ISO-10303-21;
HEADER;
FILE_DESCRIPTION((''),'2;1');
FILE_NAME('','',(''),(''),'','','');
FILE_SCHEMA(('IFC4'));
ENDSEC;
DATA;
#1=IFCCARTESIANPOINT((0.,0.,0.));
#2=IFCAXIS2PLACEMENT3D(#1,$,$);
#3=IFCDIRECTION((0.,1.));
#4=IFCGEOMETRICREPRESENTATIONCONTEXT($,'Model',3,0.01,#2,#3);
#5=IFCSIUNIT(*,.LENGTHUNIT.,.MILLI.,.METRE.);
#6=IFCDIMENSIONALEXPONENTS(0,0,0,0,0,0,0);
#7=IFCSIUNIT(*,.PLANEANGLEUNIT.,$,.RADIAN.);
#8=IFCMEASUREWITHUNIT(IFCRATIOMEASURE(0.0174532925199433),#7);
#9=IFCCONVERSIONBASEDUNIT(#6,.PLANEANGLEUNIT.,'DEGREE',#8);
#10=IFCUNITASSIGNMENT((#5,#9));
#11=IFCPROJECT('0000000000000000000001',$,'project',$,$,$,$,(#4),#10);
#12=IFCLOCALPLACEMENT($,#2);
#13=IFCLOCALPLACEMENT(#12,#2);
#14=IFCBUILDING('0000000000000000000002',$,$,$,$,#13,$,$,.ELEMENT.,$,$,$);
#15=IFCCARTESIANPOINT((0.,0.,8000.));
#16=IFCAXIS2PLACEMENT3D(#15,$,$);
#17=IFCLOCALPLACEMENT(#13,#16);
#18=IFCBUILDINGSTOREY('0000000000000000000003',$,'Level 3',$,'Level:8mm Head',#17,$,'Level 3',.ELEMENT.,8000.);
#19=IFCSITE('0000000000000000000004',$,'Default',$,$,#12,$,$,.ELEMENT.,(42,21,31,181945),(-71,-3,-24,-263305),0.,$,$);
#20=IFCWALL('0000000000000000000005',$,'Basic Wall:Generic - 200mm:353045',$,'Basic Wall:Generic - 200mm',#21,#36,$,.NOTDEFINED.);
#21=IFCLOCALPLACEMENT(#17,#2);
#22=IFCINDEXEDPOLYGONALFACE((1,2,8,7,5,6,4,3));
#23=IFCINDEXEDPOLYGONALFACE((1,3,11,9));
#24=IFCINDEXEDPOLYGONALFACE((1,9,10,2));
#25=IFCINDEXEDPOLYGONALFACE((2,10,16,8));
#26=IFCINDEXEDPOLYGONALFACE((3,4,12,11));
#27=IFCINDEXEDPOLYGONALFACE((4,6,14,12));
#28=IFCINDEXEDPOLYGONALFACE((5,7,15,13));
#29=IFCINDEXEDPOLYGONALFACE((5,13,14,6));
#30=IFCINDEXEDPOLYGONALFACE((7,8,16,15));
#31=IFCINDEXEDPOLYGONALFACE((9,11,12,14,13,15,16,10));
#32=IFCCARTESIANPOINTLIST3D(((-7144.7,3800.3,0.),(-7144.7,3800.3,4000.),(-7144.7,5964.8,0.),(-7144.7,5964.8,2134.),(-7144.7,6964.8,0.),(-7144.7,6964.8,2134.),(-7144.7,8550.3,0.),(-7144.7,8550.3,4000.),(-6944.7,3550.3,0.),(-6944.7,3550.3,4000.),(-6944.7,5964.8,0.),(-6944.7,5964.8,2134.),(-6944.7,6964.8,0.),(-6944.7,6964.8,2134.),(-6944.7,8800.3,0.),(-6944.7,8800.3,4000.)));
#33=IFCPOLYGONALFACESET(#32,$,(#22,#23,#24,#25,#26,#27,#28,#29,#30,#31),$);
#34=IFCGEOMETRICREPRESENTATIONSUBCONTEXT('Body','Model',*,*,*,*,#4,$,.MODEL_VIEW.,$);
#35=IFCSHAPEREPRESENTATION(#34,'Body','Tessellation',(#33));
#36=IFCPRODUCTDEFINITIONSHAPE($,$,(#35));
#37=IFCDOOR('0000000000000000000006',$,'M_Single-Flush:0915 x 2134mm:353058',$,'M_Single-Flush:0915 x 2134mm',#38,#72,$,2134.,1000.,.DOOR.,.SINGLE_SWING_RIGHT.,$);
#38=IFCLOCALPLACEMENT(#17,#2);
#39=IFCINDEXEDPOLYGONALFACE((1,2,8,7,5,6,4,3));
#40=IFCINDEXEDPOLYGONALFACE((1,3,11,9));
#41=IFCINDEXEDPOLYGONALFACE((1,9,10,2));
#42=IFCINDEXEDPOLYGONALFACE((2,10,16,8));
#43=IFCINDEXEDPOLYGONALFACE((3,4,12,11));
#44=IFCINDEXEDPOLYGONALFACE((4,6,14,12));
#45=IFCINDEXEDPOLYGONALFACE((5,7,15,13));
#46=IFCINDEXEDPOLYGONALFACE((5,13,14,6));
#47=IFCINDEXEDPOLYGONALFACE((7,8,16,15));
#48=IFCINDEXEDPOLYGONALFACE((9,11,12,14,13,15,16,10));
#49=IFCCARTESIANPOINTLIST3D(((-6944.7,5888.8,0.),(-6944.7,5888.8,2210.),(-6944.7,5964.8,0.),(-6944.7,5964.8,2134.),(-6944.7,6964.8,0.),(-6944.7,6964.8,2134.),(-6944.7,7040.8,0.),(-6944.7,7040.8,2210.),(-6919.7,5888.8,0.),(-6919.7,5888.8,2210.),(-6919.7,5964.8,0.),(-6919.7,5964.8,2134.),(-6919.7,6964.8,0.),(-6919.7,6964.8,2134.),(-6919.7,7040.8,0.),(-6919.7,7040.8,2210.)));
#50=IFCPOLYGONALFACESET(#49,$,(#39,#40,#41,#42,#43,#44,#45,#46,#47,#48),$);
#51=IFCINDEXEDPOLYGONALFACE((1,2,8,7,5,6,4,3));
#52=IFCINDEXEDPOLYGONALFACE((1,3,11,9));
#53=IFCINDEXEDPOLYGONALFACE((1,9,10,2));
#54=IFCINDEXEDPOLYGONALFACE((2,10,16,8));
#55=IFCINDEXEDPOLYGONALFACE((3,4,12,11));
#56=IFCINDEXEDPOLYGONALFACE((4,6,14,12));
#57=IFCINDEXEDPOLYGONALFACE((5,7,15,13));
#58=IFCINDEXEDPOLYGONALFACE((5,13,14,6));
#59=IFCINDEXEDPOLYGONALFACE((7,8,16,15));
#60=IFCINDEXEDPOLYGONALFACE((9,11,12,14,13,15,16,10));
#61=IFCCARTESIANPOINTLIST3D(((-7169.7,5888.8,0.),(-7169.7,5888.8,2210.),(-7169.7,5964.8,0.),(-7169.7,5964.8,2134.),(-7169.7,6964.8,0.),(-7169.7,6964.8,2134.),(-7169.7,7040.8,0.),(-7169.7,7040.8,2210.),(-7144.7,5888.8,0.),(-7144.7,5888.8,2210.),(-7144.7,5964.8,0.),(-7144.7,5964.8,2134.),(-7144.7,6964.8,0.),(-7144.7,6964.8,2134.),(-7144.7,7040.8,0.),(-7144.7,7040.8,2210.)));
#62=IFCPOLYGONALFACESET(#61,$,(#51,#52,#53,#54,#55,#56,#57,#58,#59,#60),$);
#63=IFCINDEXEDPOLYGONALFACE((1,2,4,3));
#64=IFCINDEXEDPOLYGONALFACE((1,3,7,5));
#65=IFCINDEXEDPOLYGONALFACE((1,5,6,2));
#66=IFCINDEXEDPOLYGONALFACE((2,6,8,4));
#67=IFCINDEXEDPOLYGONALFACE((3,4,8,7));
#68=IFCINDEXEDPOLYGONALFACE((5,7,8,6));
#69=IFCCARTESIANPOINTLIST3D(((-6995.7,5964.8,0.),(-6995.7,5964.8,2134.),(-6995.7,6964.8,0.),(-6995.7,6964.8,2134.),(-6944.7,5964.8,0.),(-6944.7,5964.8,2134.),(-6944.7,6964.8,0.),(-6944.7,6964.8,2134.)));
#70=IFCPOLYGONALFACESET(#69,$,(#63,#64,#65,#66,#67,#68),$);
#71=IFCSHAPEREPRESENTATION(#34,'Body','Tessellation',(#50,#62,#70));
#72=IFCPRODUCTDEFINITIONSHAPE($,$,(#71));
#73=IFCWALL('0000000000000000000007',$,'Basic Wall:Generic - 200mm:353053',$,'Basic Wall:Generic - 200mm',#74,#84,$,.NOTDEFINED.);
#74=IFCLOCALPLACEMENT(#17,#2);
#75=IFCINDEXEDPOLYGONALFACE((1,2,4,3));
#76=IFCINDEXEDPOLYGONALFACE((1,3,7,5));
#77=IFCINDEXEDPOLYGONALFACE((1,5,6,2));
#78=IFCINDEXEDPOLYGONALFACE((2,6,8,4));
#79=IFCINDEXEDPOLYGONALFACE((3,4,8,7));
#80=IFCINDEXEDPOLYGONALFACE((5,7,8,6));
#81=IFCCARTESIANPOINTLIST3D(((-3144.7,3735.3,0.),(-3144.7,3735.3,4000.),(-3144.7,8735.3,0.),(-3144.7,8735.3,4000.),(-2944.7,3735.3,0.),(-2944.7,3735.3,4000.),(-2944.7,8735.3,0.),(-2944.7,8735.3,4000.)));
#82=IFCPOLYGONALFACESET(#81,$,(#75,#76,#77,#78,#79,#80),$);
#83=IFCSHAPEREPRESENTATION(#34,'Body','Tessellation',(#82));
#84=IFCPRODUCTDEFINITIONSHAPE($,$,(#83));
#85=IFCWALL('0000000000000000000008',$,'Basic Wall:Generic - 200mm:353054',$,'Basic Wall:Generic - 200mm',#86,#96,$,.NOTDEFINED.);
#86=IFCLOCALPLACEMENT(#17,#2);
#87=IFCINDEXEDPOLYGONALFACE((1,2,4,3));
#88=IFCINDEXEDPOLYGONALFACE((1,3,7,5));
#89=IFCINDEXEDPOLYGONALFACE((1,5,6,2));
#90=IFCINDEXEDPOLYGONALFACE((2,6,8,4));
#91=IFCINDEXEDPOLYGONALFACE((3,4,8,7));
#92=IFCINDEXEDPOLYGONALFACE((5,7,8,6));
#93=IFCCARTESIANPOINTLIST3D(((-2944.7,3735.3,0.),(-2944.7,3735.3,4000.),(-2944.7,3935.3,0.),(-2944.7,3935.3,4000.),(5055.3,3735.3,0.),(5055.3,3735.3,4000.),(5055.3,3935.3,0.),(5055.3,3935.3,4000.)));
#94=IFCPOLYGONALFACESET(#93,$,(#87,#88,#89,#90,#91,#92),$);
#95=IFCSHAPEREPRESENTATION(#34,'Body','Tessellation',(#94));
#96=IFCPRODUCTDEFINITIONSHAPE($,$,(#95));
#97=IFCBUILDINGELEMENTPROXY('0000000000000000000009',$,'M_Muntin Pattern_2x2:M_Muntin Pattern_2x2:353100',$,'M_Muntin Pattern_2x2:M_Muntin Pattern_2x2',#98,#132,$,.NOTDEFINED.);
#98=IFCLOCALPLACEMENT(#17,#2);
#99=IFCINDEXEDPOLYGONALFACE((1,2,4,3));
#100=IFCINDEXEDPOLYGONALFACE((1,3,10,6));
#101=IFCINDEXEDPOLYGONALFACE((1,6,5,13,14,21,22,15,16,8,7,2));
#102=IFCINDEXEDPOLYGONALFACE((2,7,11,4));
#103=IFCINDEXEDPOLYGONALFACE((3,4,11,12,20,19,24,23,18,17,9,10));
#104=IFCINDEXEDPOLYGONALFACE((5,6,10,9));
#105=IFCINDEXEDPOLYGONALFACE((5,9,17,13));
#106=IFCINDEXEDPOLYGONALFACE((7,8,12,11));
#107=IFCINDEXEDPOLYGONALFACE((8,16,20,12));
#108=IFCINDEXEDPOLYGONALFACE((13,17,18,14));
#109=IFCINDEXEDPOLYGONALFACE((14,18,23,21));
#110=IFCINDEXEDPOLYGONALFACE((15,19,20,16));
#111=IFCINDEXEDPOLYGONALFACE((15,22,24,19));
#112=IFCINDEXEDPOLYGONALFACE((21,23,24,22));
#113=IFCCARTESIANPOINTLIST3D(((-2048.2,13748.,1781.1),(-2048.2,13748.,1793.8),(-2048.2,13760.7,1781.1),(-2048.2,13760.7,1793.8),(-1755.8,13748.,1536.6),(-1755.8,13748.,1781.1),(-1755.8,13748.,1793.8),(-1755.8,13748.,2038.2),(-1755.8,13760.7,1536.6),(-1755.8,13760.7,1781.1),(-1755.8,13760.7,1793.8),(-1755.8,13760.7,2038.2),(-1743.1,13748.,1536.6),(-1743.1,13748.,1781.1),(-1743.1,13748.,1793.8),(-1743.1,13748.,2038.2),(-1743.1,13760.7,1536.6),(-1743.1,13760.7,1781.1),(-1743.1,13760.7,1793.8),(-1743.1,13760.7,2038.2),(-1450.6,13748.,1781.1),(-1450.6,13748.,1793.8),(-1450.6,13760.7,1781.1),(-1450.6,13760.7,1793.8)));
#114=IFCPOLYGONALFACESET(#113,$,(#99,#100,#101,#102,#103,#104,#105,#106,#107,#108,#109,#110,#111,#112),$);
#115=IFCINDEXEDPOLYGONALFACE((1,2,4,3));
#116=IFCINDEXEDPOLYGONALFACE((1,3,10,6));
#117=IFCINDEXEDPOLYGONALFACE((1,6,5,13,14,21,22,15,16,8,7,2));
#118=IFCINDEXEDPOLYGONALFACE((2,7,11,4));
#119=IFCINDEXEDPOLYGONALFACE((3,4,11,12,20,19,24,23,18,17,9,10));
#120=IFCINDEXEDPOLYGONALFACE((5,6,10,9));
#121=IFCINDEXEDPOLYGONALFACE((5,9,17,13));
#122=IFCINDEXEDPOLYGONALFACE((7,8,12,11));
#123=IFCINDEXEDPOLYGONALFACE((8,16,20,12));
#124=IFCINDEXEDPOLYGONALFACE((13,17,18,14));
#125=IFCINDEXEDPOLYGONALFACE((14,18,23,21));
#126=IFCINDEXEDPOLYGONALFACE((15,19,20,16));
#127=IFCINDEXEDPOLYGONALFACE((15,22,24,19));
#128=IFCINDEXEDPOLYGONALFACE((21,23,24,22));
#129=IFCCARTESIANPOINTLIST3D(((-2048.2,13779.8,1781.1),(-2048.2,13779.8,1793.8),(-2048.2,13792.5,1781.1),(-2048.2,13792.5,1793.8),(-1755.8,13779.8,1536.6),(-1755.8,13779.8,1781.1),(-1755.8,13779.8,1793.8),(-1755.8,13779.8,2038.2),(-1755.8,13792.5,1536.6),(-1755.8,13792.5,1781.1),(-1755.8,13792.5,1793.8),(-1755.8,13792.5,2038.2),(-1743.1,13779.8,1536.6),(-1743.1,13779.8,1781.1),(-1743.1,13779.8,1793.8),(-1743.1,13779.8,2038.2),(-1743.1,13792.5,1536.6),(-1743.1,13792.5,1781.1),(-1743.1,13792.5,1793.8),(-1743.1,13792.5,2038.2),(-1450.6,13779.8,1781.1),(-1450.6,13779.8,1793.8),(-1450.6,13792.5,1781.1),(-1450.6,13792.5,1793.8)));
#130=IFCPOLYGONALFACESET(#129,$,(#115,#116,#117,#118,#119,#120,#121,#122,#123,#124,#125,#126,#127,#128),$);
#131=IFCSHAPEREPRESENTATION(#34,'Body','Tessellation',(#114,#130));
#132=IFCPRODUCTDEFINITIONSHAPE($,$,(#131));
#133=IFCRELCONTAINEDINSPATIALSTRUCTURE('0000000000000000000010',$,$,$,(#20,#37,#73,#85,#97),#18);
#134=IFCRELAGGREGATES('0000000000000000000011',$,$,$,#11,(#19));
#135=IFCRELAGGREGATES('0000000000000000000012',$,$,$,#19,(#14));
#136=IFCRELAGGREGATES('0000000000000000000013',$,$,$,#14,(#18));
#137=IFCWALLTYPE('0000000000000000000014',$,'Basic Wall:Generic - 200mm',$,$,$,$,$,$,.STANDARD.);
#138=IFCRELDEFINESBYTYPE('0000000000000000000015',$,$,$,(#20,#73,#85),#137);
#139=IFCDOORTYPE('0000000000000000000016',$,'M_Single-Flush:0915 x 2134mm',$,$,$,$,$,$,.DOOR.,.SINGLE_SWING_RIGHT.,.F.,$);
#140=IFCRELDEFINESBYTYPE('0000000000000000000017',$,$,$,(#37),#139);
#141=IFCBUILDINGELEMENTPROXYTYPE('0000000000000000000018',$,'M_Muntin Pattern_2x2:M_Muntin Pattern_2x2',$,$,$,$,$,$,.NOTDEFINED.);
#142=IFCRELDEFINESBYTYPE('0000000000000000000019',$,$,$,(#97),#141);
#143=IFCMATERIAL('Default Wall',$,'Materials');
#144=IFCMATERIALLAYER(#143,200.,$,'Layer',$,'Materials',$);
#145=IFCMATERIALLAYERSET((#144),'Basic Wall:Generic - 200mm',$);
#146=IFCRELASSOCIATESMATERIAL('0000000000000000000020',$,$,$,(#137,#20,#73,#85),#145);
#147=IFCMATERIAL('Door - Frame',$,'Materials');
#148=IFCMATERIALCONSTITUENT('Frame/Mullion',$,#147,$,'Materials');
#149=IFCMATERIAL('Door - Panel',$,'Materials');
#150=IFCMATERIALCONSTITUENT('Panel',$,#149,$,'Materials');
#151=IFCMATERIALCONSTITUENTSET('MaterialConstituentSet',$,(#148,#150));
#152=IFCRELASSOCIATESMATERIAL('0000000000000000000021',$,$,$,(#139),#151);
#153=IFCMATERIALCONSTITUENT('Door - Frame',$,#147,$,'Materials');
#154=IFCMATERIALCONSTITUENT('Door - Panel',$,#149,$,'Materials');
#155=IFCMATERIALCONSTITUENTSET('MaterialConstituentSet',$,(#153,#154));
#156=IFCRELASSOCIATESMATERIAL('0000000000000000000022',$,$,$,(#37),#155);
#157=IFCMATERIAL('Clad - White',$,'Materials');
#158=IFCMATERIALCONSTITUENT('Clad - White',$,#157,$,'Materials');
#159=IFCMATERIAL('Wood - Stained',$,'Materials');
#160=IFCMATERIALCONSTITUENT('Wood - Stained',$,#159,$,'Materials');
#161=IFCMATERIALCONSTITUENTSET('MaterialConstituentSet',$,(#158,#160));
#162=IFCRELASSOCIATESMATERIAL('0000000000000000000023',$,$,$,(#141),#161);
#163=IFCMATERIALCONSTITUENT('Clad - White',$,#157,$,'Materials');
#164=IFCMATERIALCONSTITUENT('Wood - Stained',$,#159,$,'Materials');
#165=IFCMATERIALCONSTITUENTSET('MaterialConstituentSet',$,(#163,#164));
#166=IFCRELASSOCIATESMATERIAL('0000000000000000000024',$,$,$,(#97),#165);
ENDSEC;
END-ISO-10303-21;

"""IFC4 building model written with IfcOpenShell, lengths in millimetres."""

from ifc_helpers import new_model, entity, si_unit, converted_unit, direction, frame, frame_2d, origin, place, context, subcontext, project, spatial, polyline, rectangle, outline, extrude, source, transform, mapped, material, layer, layer_set, layer_usage, constituent, constituent_set, type_object, type_shapes, element, fill, save


model = new_model("IFC4")

# Units and contexts
model_context = context("Model", 3, precision=0.01, world=origin(), true_north=direction((0.0, 1.0)))
body_context = subcontext(model_context, "Body", "Model", "MODEL_VIEW")
ifc_project = project(units=[si_unit("LENGTHUNIT", "METRE", prefix="MILLI"), converted_unit("PLANEANGLEUNIT", "DEGREE", entity("IfcRatioMeasure", 0.0174532925199433), si_unit("PLANEANGLEUNIT", "RADIAN"), dimensions=[0, 0, 0, 0, 0, 0, 0])], contexts=[model_context])

# Site, building, storey
site_placement = place(None, origin())
site = spatial("IfcSite", under=ifc_project, at=site_placement, Name="Default", CompositionType="ELEMENT", RefLatitude=(42, 21, 31, 181945), RefLongitude=(-71, -3, -24, -263305), RefElevation=0.0)
building_placement = place(site_placement, origin())
building = spatial("IfcBuilding", under=site, at=building_placement, CompositionType="ELEMENT")
storey_placement = place(building_placement, frame((0.0, 0.0, 8000.0)))
storey = spatial("IfcBuildingStorey", under=building, at=storey_placement, Name="Level 3", ObjectType="Level:8mm Head", LongName="Level 3", CompositionType="ELEMENT", Elevation=8000.0)

# Shared definitions
ifc_material_1 = material(Name="Default Wall", Category="Materials")
ifc_layer = layer(ifc_material_1, 200.0, Name="Layer", Category="Materials")
ifc_layer_set = layer_set([ifc_layer], Name="Basic Wall:Generic - 200mm")
wall_type = type_object("IfcWallType", Name="Basic Wall:Generic - 200mm", PredefinedType="STANDARD", material=ifc_layer_set)
ifc_material_2 = material(Name="Door - Frame", Category="Materials")
ifc_material_3 = material(Name="Door - Panel", Category="Materials")
ifc_constituent_1 = constituent(ifc_material_2, Name="Frame/Mullion", Category="Materials")
ifc_constituent_2 = constituent(ifc_material_3, Name="Panel", Category="Materials")
ifc_constituent_set_1 = constituent_set(constituents=[ifc_constituent_1, ifc_constituent_2], Name="MaterialConstituentSet")
door_type = type_object("IfcDoorType", Name="M_Single-Flush:0915 x 2134mm", OperationType="SINGLE_SWING_RIGHT", ParameterTakesPrecedence=False, PredefinedType="DOOR", material=ifc_constituent_set_1)
shared_shape_1 = source(origin(), body_context, "Body", "SweptSolid", [
    extrude(outline(polyline([(-576.0, -1124.0), (576.0, -1124.0), (576.0, 1086.0), (500.0, 1086.0), (500.0, -1048.0), (-500.0, -1048.0), (-500.0, 1086.0), (-576.0, 1086.0), (-576.0, -1124.0)])), frame((500.0, 200.0, 1086.0), z_axis=(0.0, 1.0, 0.0), x_axis=(1.0, 0.0, 0.0)), (0.0, 0.0, 1.0), 25.0),
    extrude(outline(polyline([(-1124.0, -576.0), (1086.0, -576.0), (1086.0, -500.0), (-1048.0, -500.0), (-1048.0, 500.0), (1086.0, 500.0), (1086.0, 576.0), (-1124.0, 576.0), (-1124.0, -576.0)])), frame((500.0, -25.0, 1086.0), z_axis=(0.0, 1.0, 0.0), x_axis=(0.0, 0.0, -1.0)), (0.0, 0.0, 1.0), 25.0),
    extrude(rectangle(XDim=51.0, YDim=1000.0, at=frame_2d((0.0, 0.0), x_axis=(1.0, 0.0))), frame((500.0, 174.5, 0.0), z_axis=(0.0, 0.0, 1.0), x_axis=(0.0, 1.0, 0.0)), (0.0, 0.0, 1.0), 2134.0),
])
type_shapes(door_type, [shared_shape_1])
ifc_material_4 = material(Name="Wood - Stained", Category="Materials")

# Wall, opening, door
ifc_layer_usage_1 = layer_usage(ifc_layer_set, "AXIS2", "NEGATIVE", 100.0)
wall_1_placement = place(storey_placement, frame((-7044.7, 8800.3, 0.0), z_axis=(0.0, 0.0, 1.0), x_axis=(0.0, -1.0, 0.0)))
wall_1 = element("IfcWall", 1, at=wall_1_placement, inside=storey, type_object=wall_type, material=ifc_layer_usage_1, Name="Basic Wall:Generic - 200mm:353045", ObjectType="Basic Wall:Generic - 200mm", PredefinedType="NOTDEFINED", context=body_context, shape_type="SweptSolid", body=[
    extrude(outline(polyline([(250.0, -100.0), (5000.0, -100.0), (5250.0, 100.0), (4929.8, 100.0), (0.0, 100.0), (250.0, -100.0)])), origin(), (0.0, 0.0, 1.0), 4000.0),
])
opening_1_placement = place(wall_1_placement, frame((1835.4, -100.0, 0.0)))
opening_1 = element("IfcOpeningElement", 2, at=opening_1_placement, cuts=wall_1, PredefinedType="OPENING", context=body_context, shape_type="SweptSolid", body=[
    extrude(rectangle(XDim=1000.0, YDim=2134.0, at=frame_2d((1067.0, 500.0), x_axis=(0.0, 1.0))), frame((0.0, 0.0, 0.0), z_axis=(0.0, 1.0, 0.0), x_axis=(0.0, 0.0, 1.0)), (0.0, 0.0, 1.0), 200.0),
])
ifc_constituent_3 = constituent(ifc_material_2, Name="Door - Frame", Category="Materials")
ifc_constituent_4 = constituent(ifc_material_3, Name="Door - Panel", Category="Materials")
ifc_constituent_set_2 = constituent_set(constituents=[ifc_constituent_3, ifc_constituent_4], Name="MaterialConstituentSet")
door_1_placement = place(opening_1_placement, origin())
door_1 = element("IfcDoor", 3, at=door_1_placement, inside=storey, type_object=door_type, material=ifc_constituent_set_2, Name="M_Single-Flush:0915 x 2134mm:353058", ObjectType="M_Single-Flush:0915 x 2134mm", OperationType="SINGLE_SWING_RIGHT", OverallHeight=2134.0, OverallWidth=1000.0, PredefinedType="DOOR", context=body_context, shape_type="MappedRepresentation", body=[
    mapped(shared_shape_1, transform((0.0, 0.0, 0.0), scale=1.0)),
])
fill(opening_1, door_1)

# Walls
ifc_layer_usage_2 = layer_usage(ifc_layer_set, "AXIS2", "NEGATIVE", 100.0)
wall_2_placement = place(storey_placement, frame((-3044.7, 8735.3, 0.0), z_axis=(0.0, 0.0, 1.0), x_axis=(0.0, -1.0, 0.0)))
element("IfcWall", 4, at=wall_2_placement, inside=storey, type_object=wall_type, material=ifc_layer_usage_2, Name="Basic Wall:Generic - 200mm:353053", ObjectType="Basic Wall:Generic - 200mm", PredefinedType="NOTDEFINED", context=body_context, shape_type="SweptSolid", body=[
    extrude(rectangle(XDim=5000.0, YDim=200.0, at=frame_2d((2500.0, 0.0), x_axis=(-1.0, 0.0))), origin(), (0.0, 0.0, 1.0), 4000.0),
])
ifc_layer_usage_3 = layer_usage(ifc_layer_set, "AXIS2", "NEGATIVE", 100.0)
wall_3_placement = place(storey_placement, frame((-2944.7, 3835.3, 0.0)))
element("IfcWall", 5, at=wall_3_placement, inside=storey, type_object=wall_type, material=ifc_layer_usage_3, Name="Basic Wall:Generic - 200mm:353054", ObjectType="Basic Wall:Generic - 200mm", PredefinedType="NOTDEFINED", context=body_context, shape_type="SweptSolid", body=[
    extrude(rectangle(XDim=8000.0, YDim=200.0, at=frame_2d((4000.0, 0.0), x_axis=(-1.0, 0.0))), origin(), (0.0, 0.0, 1.0), 4000.0),
])

# Building element proxy
ifc_material_5 = material(Name="Clad - White", Category="Materials")
ifc_constituent_5 = constituent(ifc_material_5, Name="Clad - White", Category="Materials")
ifc_constituent_6 = constituent(ifc_material_4, Name="Wood - Stained", Category="Materials")
ifc_constituent_set_3 = constituent_set(constituents=[ifc_constituent_5, ifc_constituent_6], Name="MaterialConstituentSet")
ifc_constituent_7 = constituent(ifc_material_5, Name="Clad - White", Category="Materials")
ifc_constituent_8 = constituent(ifc_material_4, Name="Wood - Stained", Category="Materials")
ifc_constituent_set_4 = constituent_set(constituents=[ifc_constituent_7, ifc_constituent_8], Name="MaterialConstituentSet")
building_element_proxy_type_1 = type_object("IfcBuildingElementProxyType", Name="M_Muntin Pattern_2x2:M_Muntin Pattern_2x2", PredefinedType="NOTDEFINED", material=ifc_constituent_set_4)
shared_shape_2 = source(origin(), body_context, "Body", "SweptSolid", [
    extrude(outline(polyline([(6.4, -6.4), (250.8, -6.4), (250.8, 6.3), (6.4, 6.3), (6.4, 298.8), (-6.3, 298.8), (-6.3, 6.3), (-250.8, 6.3), (-250.8, -6.4), (-6.3, -6.4), (-6.3, -298.8), (6.4, -298.8), (6.4, -6.4)])), frame((0.0, 9.5, 250.8), z_axis=(0.0, 1.0, 0.0), x_axis=(0.0, 0.0, 1.0)), (0.0, 0.0, 1.0), 12.7),
    extrude(outline(polyline([(6.4, -6.4), (250.8, -6.4), (250.8, 6.3), (6.4, 6.3), (6.4, 298.8), (-6.3, 298.8), (-6.3, 6.3), (-250.8, 6.3), (-250.8, -6.4), (-6.3, -6.4), (-6.3, -298.8), (6.4, -298.8), (6.4, -6.4)])), frame((0.0, -22.2, 250.8), z_axis=(0.0, 1.0, 0.0), x_axis=(0.0, 0.0, 1.0)), (0.0, 0.0, 1.0), 12.7),
])
type_shapes(building_element_proxy_type_1, [shared_shape_2])
proxy_1_placement = place(storey_placement, frame((-1749.4, 13770.3, 1536.6), z_axis=(0.0, 0.0, 1.0), x_axis=(-1.0, 0.0, 0.0)))
element("IfcBuildingElementProxy", 6, at=proxy_1_placement, inside=storey, type_object=building_element_proxy_type_1, material=ifc_constituent_set_3, Name="M_Muntin Pattern_2x2:M_Muntin Pattern_2x2:353100", ObjectType="M_Muntin Pattern_2x2:M_Muntin Pattern_2x2", PredefinedType="NOTDEFINED", context=body_context, shape_type="MappedRepresentation", body=[
    mapped(shared_shape_2, transform((0.0, 0.0, 0.0), scale=1.0)),
])

save(model, "model.ifc")
